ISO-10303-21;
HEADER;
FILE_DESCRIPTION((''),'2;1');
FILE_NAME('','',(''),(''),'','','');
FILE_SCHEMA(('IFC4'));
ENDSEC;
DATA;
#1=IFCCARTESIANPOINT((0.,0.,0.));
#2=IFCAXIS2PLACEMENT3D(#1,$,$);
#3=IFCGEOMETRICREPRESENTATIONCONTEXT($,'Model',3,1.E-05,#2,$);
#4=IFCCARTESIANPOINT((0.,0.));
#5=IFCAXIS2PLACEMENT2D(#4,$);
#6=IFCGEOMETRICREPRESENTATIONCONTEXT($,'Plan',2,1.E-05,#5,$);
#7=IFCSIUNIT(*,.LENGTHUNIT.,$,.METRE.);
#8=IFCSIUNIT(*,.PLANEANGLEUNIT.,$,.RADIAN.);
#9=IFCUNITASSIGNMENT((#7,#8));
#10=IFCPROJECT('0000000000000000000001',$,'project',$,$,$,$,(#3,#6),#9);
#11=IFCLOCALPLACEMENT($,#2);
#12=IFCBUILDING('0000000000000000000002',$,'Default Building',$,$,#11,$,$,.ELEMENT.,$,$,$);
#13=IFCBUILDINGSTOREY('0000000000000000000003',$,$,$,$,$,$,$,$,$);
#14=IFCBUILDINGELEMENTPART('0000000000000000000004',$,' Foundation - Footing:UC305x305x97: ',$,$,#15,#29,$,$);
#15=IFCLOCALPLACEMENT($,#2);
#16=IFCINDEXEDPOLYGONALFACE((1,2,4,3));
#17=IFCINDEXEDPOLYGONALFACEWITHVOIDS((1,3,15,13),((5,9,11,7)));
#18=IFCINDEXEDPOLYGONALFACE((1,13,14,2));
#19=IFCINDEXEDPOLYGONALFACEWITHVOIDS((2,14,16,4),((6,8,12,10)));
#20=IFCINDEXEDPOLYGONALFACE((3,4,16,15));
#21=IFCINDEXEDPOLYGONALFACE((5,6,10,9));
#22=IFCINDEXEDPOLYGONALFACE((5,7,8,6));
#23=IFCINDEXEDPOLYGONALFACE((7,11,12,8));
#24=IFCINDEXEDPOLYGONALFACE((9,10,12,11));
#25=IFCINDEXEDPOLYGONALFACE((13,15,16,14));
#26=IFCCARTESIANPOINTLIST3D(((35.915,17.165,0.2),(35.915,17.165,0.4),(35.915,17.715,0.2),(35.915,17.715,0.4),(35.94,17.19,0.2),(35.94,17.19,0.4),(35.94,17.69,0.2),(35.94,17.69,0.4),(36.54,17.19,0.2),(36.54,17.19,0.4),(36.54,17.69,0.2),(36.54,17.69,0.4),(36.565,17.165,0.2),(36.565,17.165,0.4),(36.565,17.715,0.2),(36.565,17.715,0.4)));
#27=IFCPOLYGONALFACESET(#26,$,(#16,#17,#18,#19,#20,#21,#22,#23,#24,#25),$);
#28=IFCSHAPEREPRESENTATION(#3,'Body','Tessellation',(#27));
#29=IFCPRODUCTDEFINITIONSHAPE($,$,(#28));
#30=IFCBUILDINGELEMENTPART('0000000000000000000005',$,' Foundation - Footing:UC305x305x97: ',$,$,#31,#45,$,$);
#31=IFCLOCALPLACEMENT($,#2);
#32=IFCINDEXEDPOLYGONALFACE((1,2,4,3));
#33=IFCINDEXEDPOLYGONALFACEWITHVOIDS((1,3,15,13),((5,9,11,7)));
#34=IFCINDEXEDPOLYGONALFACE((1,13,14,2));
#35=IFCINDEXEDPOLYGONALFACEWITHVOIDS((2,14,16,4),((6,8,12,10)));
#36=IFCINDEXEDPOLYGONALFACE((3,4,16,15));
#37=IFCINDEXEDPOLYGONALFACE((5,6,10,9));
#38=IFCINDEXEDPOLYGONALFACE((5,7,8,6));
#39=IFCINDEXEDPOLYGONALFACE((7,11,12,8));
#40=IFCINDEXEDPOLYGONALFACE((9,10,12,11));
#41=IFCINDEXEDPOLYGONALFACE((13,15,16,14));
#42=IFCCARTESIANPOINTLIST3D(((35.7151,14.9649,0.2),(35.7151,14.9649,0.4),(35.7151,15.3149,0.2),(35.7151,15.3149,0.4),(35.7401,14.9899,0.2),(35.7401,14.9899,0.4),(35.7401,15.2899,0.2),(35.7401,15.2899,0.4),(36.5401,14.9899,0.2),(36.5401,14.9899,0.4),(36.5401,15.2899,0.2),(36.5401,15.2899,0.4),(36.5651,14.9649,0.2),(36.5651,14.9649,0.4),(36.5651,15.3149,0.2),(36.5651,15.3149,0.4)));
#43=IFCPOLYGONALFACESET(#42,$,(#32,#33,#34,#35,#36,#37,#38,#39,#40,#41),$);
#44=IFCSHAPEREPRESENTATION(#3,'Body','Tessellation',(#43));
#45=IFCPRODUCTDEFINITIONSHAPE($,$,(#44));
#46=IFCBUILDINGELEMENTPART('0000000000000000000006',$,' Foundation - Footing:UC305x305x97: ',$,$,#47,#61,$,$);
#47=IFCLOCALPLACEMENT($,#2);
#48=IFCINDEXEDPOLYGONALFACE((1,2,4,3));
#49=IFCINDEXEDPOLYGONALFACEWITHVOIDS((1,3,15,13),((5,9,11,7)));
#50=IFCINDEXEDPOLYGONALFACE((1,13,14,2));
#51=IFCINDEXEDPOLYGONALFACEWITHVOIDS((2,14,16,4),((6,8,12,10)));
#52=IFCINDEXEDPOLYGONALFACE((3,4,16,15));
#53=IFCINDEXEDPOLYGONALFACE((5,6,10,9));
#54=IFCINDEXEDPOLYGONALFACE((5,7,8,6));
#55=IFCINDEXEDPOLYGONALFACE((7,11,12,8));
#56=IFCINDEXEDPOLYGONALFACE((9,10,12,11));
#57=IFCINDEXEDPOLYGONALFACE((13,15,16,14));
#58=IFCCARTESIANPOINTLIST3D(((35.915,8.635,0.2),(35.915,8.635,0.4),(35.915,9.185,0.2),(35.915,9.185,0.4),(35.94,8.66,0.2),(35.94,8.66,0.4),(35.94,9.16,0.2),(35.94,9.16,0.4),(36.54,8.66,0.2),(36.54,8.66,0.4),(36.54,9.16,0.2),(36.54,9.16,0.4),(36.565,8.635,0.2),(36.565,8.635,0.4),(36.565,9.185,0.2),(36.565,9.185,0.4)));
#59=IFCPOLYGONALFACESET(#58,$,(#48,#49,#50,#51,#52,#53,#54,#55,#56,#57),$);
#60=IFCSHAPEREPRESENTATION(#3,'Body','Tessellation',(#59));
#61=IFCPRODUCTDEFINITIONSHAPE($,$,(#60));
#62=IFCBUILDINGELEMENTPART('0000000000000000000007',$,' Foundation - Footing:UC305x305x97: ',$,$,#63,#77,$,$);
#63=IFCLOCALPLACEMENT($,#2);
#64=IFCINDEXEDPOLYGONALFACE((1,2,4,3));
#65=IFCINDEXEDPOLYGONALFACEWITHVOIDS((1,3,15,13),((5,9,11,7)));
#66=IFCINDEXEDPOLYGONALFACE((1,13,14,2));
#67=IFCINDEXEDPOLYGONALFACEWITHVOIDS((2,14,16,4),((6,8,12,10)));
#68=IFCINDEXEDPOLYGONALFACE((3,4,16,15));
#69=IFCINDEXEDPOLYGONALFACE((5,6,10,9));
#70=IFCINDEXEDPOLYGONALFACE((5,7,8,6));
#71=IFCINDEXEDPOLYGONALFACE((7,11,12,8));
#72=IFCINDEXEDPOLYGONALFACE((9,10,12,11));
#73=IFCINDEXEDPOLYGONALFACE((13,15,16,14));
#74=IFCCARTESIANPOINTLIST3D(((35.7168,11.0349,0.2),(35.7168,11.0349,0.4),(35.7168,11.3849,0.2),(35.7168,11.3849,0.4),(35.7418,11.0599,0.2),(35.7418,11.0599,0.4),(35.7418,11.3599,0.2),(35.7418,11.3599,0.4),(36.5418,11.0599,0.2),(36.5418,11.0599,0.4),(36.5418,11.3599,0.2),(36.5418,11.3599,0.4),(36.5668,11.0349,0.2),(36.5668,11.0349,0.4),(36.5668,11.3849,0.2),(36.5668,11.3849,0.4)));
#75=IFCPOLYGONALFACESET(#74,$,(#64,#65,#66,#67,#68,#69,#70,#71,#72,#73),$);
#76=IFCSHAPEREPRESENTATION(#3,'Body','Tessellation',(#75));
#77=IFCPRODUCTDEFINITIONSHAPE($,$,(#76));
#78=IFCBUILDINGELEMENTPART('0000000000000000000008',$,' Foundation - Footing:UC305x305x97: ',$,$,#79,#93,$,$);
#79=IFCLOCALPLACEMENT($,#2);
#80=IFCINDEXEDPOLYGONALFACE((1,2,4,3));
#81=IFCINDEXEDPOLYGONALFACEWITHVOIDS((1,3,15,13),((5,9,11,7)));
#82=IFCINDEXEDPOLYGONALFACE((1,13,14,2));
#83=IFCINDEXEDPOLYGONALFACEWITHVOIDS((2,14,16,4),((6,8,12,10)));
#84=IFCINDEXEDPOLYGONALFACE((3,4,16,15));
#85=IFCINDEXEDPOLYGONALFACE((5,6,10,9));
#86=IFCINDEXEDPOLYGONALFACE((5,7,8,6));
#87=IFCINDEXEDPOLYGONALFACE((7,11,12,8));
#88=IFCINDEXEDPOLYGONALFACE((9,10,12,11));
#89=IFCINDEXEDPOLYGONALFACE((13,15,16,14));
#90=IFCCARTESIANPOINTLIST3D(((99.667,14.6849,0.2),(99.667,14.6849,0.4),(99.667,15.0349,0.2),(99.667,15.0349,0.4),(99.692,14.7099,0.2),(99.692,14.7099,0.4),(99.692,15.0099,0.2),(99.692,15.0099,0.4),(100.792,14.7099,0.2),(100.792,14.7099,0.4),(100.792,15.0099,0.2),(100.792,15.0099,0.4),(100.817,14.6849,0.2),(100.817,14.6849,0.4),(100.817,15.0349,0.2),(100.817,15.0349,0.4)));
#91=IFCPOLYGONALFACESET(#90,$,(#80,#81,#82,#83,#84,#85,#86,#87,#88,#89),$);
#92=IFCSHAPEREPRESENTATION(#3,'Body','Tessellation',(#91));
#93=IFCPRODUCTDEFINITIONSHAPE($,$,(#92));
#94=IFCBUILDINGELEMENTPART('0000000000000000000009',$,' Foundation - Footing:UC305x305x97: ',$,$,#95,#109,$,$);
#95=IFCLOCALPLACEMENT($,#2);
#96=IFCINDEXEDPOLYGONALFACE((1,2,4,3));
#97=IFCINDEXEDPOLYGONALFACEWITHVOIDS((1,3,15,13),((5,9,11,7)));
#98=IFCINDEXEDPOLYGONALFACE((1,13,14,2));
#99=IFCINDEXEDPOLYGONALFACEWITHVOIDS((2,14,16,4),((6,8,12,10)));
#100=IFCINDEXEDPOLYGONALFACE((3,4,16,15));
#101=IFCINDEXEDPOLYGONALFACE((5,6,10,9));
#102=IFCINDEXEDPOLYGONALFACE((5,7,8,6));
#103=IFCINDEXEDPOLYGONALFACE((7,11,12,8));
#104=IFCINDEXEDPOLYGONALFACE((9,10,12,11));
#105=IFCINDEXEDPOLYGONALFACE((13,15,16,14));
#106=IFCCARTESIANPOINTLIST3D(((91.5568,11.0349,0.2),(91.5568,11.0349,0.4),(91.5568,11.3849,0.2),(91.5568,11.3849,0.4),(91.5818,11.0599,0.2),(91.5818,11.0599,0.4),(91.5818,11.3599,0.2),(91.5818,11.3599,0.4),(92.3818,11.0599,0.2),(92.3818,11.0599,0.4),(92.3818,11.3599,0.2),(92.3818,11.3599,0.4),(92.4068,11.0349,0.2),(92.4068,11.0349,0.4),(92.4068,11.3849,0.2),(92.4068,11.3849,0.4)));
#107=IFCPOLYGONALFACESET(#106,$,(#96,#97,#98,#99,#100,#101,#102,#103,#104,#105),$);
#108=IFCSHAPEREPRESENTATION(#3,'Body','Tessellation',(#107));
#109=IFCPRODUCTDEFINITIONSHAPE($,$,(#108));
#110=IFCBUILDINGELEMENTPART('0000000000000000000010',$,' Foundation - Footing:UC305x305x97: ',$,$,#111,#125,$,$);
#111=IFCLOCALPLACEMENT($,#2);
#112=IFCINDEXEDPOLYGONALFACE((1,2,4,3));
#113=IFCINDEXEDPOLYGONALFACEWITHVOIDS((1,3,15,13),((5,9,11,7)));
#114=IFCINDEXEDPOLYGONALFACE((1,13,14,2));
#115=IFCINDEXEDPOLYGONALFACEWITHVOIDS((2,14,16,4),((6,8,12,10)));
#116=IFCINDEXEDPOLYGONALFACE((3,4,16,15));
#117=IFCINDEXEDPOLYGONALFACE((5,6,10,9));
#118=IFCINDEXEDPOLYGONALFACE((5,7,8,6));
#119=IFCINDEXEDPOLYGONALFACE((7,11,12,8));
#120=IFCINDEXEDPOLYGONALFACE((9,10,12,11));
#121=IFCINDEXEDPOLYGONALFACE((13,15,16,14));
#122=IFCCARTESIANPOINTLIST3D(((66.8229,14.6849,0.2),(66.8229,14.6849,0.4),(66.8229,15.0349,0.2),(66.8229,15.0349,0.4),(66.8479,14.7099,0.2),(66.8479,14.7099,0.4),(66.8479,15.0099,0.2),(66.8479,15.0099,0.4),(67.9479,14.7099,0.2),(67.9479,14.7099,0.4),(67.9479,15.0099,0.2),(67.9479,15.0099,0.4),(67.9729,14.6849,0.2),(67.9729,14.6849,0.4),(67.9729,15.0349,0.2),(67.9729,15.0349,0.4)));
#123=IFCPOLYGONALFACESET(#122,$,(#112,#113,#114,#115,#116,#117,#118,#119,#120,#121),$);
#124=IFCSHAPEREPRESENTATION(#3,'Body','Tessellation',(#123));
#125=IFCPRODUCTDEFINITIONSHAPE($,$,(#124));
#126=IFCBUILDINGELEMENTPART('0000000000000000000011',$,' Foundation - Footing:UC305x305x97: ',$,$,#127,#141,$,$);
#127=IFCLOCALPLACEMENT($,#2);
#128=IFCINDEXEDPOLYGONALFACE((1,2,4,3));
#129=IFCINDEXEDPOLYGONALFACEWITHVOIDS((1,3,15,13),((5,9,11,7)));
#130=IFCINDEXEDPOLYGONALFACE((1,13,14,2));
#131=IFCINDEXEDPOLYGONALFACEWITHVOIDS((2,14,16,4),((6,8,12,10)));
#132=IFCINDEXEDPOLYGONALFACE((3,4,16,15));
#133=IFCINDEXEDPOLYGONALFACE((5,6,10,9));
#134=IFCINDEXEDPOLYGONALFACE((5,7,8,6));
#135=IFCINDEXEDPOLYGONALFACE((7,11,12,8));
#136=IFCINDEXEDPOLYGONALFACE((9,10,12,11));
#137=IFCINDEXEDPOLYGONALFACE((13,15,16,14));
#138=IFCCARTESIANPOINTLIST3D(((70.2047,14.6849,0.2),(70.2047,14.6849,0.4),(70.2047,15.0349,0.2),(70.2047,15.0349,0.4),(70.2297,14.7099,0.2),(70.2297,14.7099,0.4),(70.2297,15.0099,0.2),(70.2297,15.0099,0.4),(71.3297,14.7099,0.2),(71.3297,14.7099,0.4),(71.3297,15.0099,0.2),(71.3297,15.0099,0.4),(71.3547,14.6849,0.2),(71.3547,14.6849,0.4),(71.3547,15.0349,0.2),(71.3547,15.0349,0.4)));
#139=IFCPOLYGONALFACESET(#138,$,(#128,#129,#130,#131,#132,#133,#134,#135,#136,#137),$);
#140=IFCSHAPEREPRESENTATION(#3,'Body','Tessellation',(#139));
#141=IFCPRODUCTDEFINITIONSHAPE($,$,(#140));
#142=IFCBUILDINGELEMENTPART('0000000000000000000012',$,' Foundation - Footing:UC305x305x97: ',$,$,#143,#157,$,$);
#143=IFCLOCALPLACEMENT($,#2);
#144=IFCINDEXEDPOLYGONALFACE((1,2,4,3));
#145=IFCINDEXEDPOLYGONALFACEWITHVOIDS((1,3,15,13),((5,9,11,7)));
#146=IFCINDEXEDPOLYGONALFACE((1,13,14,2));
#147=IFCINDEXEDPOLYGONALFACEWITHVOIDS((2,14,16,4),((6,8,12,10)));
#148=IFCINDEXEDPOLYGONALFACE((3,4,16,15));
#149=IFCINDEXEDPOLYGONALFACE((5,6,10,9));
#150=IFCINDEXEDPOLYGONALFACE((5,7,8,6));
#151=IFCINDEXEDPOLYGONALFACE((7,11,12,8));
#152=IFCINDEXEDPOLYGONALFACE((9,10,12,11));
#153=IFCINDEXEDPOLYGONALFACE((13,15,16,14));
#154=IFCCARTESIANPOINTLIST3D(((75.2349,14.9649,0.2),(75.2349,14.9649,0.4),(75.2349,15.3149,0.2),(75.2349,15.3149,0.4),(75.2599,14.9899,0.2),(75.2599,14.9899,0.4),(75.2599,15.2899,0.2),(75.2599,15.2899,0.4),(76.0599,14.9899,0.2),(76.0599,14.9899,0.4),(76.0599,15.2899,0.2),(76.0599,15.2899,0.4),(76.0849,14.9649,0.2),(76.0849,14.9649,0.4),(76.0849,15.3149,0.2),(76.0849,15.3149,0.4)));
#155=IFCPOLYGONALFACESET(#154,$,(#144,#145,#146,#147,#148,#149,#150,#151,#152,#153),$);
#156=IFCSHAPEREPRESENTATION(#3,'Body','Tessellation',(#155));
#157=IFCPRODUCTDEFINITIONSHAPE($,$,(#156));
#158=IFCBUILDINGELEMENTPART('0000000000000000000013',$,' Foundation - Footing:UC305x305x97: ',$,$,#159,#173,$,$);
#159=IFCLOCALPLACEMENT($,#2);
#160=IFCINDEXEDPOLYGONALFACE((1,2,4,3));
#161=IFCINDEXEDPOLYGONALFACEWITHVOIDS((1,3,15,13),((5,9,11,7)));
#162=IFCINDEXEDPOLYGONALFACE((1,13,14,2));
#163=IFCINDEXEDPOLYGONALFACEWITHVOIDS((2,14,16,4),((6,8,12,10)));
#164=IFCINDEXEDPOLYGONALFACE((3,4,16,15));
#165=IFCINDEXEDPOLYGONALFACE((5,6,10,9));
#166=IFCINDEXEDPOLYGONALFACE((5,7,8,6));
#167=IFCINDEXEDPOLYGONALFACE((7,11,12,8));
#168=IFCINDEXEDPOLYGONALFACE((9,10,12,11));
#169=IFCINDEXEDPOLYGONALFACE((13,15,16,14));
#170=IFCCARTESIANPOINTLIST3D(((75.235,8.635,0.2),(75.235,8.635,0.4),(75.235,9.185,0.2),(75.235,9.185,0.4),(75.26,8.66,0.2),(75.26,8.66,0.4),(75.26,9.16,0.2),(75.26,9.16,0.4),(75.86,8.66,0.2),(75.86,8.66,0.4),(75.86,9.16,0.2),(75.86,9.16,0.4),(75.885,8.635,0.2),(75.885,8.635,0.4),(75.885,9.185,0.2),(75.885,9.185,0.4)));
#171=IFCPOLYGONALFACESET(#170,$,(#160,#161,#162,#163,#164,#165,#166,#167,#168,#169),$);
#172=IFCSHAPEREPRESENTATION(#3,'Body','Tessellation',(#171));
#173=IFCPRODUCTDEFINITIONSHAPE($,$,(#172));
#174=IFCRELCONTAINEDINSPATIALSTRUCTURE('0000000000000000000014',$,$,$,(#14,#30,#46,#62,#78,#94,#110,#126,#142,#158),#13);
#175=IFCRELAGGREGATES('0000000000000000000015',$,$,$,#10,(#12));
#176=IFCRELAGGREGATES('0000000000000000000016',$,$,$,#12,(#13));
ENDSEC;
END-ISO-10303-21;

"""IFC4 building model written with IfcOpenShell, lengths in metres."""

from ifc_helpers import new_model, si_unit, origin, origin_2d, place, context, project, spatial, polyline, outline, extrude, element, save


model = new_model("IFC4")

# Units and contexts
model_context = context("Model", 3, precision=1e-05, world=origin())
plan_context = context("Plan", 2, precision=1e-05, world=origin_2d())
ifc_project = project(units=[si_unit("LENGTHUNIT", "METRE"), si_unit("PLANEANGLEUNIT", "RADIAN")], contexts=[model_context, plan_context])

# Building, storey
building_placement = place(None, origin())
building = spatial("IfcBuilding", under=ifc_project, at=building_placement, Name="Default Building", CompositionType="ELEMENT")
storey = spatial("IfcBuildingStorey", under=building)

# Building element parts, openings
building_element_part_1 = element("IfcBuildingElementPart", 1, inside=storey, Name=" Foundation - Footing:UC305x305x97: ", context=model_context, shape_type="SweptSolid", body=[
    extrude(outline(polyline([(36.565, 17.715, 0.2), (35.915, 17.715, 0.2), (35.915, 17.165, 0.2), (36.565, 17.165, 0.2), (36.565, 17.715, 0.2)])), None, (0.0, 0.0, 1.0), 0.2),
])
element("IfcOpeningElement", 2, inside=storey, cuts=building_element_part_1, context=model_context, shape_type="SweptSolid", body=[
    extrude(outline(polyline([(36.54, 17.69, 0.2), (35.94, 17.69, 0.2), (35.94, 17.19, 0.2), (36.54, 17.19, 0.2), (36.54, 17.69, 0.2)])), None, (0.0, 0.0, 1.0), 0.2),
])
building_element_part_2 = element("IfcBuildingElementPart", 3, inside=storey, Name=" Foundation - Footing:UC305x305x97: ", context=model_context, shape_type="SweptSolid", body=[
    extrude(outline(polyline([(36.5651, 15.3149, 0.2), (35.7151, 15.3149, 0.2), (35.7151, 14.9649, 0.2), (36.5651, 14.9649, 0.2), (36.5651, 15.3149, 0.2)])), None, (0.0, 0.0, 1.0), 0.2),
])
element("IfcOpeningElement", 4, inside=storey, cuts=building_element_part_2, context=model_context, shape_type="SweptSolid", body=[
    extrude(outline(polyline([(36.5401, 15.2899, 0.2), (35.7401, 15.2899, 0.2), (35.7401, 14.9899, 0.2), (36.5401, 14.9899, 0.2), (36.5401, 15.2899, 0.2)])), None, (0.0, 0.0, 1.0), 0.2),
])
building_element_part_3 = element("IfcBuildingElementPart", 5, inside=storey, Name=" Foundation - Footing:UC305x305x97: ", context=model_context, shape_type="SweptSolid", body=[
    extrude(outline(polyline([(36.565, 8.635, 0.2), (35.915, 8.635, 0.2), (35.915, 9.185, 0.2), (36.565, 9.185, 0.2), (36.565, 8.635, 0.2)])), None, (0.0, 0.0, 1.0), 0.2),
])
element("IfcOpeningElement", 6, inside=storey, cuts=building_element_part_3, context=model_context, shape_type="SweptSolid", body=[
    extrude(outline(polyline([(36.54, 8.66, 0.2), (35.94, 8.66, 0.2), (35.94, 9.16, 0.2), (36.54, 9.16, 0.2), (36.54, 8.66, 0.2)])), None, (0.0, 0.0, 1.0), 0.2),
])
building_element_part_4 = element("IfcBuildingElementPart", 7, inside=storey, Name=" Foundation - Footing:UC305x305x97: ", context=model_context, shape_type="SweptSolid", body=[
    extrude(outline(polyline([(36.5668, 11.0349, 0.2), (35.7168, 11.0349, 0.2), (35.7168, 11.3849, 0.2), (36.5668, 11.3849, 0.2), (36.5668, 11.0349, 0.2)])), None, (0.0, 0.0, 1.0), 0.2),
])
element("IfcOpeningElement", 8, inside=storey, cuts=building_element_part_4, context=model_context, shape_type="SweptSolid", body=[
    extrude(outline(polyline([(36.5418, 11.0599, 0.2), (35.7418, 11.0599, 0.2), (35.7418, 11.3599, 0.2), (36.5418, 11.3599, 0.2), (36.5418, 11.0599, 0.2)])), None, (0.0, 0.0, 1.0), 0.2),
])
building_element_part_5 = element("IfcBuildingElementPart", 9, inside=storey, Name=" Foundation - Footing:UC305x305x97: ", context=model_context, shape_type="SweptSolid", body=[
    extrude(outline(polyline([(100.817, 14.6849, 0.2), (100.817, 15.0349, 0.2), (99.667, 15.0349, 0.2), (99.667, 14.6849, 0.2), (100.817, 14.6849, 0.2)])), None, (0.0, 0.0, 1.0), 0.2),
])
element("IfcOpeningElement", 10, inside=storey, cuts=building_element_part_5, context=model_context, shape_type="SweptSolid", body=[
    extrude(outline(polyline([(100.792, 14.7099, 0.2), (100.792, 15.0099, 0.2), (99.692, 15.0099, 0.2), (99.692, 14.7099, 0.2), (100.792, 14.7099, 0.2)])), None, (0.0, 0.0, 1.0), 0.2),
])
building_element_part_6 = element("IfcBuildingElementPart", 11, inside=storey, Name=" Foundation - Footing:UC305x305x97: ", context=model_context, shape_type="SweptSolid", body=[
    extrude(outline(polyline([(92.4068, 11.0349, 0.2), (91.5568, 11.0349, 0.2), (91.5568, 11.3849, 0.2), (92.4068, 11.3849, 0.2), (92.4068, 11.0349, 0.2)])), None, (0.0, 0.0, 1.0), 0.2),
])
element("IfcOpeningElement", 12, inside=storey, cuts=building_element_part_6, context=model_context, shape_type="SweptSolid", body=[
    extrude(outline(polyline([(92.3818, 11.0599, 0.2), (91.5818, 11.0599, 0.2), (91.5818, 11.3599, 0.2), (92.3818, 11.3599, 0.2), (92.3818, 11.0599, 0.2)])), None, (0.0, 0.0, 1.0), 0.2),
])
building_element_part_7 = element("IfcBuildingElementPart", 13, inside=storey, Name=" Foundation - Footing:UC305x305x97: ", context=model_context, shape_type="SweptSolid", body=[
    extrude(outline(polyline([(66.8229, 14.6849, 0.2), (66.8229, 15.0349, 0.2), (67.9729, 15.0349, 0.2), (67.9729, 14.6849, 0.2), (66.8229, 14.6849, 0.2)])), None, (0.0, 0.0, 1.0), 0.2),
])
element("IfcOpeningElement", 14, inside=storey, cuts=building_element_part_7, context=model_context, shape_type="SweptSolid", body=[
    extrude(outline(polyline([(66.8479, 14.7099, 0.2), (66.8479, 15.0099, 0.2), (67.9479, 15.0099, 0.2), (67.9479, 14.7099, 0.2), (66.8479, 14.7099, 0.2)])), None, (0.0, 0.0, 1.0), 0.2),
])
building_element_part_8 = element("IfcBuildingElementPart", 15, inside=storey, Name=" Foundation - Footing:UC305x305x97: ", context=model_context, shape_type="SweptSolid", body=[
    extrude(outline(polyline([(70.2047, 15.0349, 0.2), (71.3547, 15.0349, 0.2), (71.3547, 14.6849, 0.2), (70.2047, 14.6849, 0.2), (70.2047, 15.0349, 0.2)])), None, (0.0, 0.0, 1.0), 0.2),
])
element("IfcOpeningElement", 16, inside=storey, cuts=building_element_part_8, context=model_context, shape_type="SweptSolid", body=[
    extrude(outline(polyline([(70.2297, 15.0099, 0.2), (71.3297, 15.0099, 0.2), (71.3297, 14.7099, 0.2), (70.2297, 14.7099, 0.2), (70.2297, 15.0099, 0.2)])), None, (0.0, 0.0, 1.0), 0.2),
])
building_element_part_9 = element("IfcBuildingElementPart", 17, inside=storey, Name=" Foundation - Footing:UC305x305x97: ", context=model_context, shape_type="SweptSolid", body=[
    extrude(outline(polyline([(75.2349, 15.3149, 0.2), (76.0849, 15.3149, 0.2), (76.0849, 14.9649, 0.2), (75.2349, 14.9649, 0.2), (75.2349, 15.3149, 0.2)])), None, (0.0, 0.0, 1.0), 0.2),
])
element("IfcOpeningElement", 18, inside=storey, cuts=building_element_part_9, context=model_context, shape_type="SweptSolid", body=[
    extrude(outline(polyline([(75.2599, 15.2899, 0.2), (76.0599, 15.2899, 0.2), (76.0599, 14.9899, 0.2), (75.2599, 14.9899, 0.2), (75.2599, 15.2899, 0.2)])), None, (0.0, 0.0, 1.0), 0.2),
])
building_element_part_10 = element("IfcBuildingElementPart", 19, inside=storey, Name=" Foundation - Footing:UC305x305x97: ", context=model_context, shape_type="SweptSolid", body=[
    extrude(outline(polyline([(75.235, 8.635, 0.2), (75.885, 8.635, 0.2), (75.885, 9.185, 0.2), (75.235, 9.185, 0.2), (75.235, 8.635, 0.2)])), None, (0.0, 0.0, 1.0), 0.2),
])
element("IfcOpeningElement", 20, inside=storey, cuts=building_element_part_10, context=model_context, shape_type="SweptSolid", body=[
    extrude(outline(polyline([(75.26, 8.66, 0.2), (75.86, 8.66, 0.2), (75.86, 9.16, 0.2), (75.26, 9.16, 0.2), (75.26, 8.66, 0.2)])), None, (0.0, 0.0, 1.0), 0.2),
])

save(model, "model.ifc")
